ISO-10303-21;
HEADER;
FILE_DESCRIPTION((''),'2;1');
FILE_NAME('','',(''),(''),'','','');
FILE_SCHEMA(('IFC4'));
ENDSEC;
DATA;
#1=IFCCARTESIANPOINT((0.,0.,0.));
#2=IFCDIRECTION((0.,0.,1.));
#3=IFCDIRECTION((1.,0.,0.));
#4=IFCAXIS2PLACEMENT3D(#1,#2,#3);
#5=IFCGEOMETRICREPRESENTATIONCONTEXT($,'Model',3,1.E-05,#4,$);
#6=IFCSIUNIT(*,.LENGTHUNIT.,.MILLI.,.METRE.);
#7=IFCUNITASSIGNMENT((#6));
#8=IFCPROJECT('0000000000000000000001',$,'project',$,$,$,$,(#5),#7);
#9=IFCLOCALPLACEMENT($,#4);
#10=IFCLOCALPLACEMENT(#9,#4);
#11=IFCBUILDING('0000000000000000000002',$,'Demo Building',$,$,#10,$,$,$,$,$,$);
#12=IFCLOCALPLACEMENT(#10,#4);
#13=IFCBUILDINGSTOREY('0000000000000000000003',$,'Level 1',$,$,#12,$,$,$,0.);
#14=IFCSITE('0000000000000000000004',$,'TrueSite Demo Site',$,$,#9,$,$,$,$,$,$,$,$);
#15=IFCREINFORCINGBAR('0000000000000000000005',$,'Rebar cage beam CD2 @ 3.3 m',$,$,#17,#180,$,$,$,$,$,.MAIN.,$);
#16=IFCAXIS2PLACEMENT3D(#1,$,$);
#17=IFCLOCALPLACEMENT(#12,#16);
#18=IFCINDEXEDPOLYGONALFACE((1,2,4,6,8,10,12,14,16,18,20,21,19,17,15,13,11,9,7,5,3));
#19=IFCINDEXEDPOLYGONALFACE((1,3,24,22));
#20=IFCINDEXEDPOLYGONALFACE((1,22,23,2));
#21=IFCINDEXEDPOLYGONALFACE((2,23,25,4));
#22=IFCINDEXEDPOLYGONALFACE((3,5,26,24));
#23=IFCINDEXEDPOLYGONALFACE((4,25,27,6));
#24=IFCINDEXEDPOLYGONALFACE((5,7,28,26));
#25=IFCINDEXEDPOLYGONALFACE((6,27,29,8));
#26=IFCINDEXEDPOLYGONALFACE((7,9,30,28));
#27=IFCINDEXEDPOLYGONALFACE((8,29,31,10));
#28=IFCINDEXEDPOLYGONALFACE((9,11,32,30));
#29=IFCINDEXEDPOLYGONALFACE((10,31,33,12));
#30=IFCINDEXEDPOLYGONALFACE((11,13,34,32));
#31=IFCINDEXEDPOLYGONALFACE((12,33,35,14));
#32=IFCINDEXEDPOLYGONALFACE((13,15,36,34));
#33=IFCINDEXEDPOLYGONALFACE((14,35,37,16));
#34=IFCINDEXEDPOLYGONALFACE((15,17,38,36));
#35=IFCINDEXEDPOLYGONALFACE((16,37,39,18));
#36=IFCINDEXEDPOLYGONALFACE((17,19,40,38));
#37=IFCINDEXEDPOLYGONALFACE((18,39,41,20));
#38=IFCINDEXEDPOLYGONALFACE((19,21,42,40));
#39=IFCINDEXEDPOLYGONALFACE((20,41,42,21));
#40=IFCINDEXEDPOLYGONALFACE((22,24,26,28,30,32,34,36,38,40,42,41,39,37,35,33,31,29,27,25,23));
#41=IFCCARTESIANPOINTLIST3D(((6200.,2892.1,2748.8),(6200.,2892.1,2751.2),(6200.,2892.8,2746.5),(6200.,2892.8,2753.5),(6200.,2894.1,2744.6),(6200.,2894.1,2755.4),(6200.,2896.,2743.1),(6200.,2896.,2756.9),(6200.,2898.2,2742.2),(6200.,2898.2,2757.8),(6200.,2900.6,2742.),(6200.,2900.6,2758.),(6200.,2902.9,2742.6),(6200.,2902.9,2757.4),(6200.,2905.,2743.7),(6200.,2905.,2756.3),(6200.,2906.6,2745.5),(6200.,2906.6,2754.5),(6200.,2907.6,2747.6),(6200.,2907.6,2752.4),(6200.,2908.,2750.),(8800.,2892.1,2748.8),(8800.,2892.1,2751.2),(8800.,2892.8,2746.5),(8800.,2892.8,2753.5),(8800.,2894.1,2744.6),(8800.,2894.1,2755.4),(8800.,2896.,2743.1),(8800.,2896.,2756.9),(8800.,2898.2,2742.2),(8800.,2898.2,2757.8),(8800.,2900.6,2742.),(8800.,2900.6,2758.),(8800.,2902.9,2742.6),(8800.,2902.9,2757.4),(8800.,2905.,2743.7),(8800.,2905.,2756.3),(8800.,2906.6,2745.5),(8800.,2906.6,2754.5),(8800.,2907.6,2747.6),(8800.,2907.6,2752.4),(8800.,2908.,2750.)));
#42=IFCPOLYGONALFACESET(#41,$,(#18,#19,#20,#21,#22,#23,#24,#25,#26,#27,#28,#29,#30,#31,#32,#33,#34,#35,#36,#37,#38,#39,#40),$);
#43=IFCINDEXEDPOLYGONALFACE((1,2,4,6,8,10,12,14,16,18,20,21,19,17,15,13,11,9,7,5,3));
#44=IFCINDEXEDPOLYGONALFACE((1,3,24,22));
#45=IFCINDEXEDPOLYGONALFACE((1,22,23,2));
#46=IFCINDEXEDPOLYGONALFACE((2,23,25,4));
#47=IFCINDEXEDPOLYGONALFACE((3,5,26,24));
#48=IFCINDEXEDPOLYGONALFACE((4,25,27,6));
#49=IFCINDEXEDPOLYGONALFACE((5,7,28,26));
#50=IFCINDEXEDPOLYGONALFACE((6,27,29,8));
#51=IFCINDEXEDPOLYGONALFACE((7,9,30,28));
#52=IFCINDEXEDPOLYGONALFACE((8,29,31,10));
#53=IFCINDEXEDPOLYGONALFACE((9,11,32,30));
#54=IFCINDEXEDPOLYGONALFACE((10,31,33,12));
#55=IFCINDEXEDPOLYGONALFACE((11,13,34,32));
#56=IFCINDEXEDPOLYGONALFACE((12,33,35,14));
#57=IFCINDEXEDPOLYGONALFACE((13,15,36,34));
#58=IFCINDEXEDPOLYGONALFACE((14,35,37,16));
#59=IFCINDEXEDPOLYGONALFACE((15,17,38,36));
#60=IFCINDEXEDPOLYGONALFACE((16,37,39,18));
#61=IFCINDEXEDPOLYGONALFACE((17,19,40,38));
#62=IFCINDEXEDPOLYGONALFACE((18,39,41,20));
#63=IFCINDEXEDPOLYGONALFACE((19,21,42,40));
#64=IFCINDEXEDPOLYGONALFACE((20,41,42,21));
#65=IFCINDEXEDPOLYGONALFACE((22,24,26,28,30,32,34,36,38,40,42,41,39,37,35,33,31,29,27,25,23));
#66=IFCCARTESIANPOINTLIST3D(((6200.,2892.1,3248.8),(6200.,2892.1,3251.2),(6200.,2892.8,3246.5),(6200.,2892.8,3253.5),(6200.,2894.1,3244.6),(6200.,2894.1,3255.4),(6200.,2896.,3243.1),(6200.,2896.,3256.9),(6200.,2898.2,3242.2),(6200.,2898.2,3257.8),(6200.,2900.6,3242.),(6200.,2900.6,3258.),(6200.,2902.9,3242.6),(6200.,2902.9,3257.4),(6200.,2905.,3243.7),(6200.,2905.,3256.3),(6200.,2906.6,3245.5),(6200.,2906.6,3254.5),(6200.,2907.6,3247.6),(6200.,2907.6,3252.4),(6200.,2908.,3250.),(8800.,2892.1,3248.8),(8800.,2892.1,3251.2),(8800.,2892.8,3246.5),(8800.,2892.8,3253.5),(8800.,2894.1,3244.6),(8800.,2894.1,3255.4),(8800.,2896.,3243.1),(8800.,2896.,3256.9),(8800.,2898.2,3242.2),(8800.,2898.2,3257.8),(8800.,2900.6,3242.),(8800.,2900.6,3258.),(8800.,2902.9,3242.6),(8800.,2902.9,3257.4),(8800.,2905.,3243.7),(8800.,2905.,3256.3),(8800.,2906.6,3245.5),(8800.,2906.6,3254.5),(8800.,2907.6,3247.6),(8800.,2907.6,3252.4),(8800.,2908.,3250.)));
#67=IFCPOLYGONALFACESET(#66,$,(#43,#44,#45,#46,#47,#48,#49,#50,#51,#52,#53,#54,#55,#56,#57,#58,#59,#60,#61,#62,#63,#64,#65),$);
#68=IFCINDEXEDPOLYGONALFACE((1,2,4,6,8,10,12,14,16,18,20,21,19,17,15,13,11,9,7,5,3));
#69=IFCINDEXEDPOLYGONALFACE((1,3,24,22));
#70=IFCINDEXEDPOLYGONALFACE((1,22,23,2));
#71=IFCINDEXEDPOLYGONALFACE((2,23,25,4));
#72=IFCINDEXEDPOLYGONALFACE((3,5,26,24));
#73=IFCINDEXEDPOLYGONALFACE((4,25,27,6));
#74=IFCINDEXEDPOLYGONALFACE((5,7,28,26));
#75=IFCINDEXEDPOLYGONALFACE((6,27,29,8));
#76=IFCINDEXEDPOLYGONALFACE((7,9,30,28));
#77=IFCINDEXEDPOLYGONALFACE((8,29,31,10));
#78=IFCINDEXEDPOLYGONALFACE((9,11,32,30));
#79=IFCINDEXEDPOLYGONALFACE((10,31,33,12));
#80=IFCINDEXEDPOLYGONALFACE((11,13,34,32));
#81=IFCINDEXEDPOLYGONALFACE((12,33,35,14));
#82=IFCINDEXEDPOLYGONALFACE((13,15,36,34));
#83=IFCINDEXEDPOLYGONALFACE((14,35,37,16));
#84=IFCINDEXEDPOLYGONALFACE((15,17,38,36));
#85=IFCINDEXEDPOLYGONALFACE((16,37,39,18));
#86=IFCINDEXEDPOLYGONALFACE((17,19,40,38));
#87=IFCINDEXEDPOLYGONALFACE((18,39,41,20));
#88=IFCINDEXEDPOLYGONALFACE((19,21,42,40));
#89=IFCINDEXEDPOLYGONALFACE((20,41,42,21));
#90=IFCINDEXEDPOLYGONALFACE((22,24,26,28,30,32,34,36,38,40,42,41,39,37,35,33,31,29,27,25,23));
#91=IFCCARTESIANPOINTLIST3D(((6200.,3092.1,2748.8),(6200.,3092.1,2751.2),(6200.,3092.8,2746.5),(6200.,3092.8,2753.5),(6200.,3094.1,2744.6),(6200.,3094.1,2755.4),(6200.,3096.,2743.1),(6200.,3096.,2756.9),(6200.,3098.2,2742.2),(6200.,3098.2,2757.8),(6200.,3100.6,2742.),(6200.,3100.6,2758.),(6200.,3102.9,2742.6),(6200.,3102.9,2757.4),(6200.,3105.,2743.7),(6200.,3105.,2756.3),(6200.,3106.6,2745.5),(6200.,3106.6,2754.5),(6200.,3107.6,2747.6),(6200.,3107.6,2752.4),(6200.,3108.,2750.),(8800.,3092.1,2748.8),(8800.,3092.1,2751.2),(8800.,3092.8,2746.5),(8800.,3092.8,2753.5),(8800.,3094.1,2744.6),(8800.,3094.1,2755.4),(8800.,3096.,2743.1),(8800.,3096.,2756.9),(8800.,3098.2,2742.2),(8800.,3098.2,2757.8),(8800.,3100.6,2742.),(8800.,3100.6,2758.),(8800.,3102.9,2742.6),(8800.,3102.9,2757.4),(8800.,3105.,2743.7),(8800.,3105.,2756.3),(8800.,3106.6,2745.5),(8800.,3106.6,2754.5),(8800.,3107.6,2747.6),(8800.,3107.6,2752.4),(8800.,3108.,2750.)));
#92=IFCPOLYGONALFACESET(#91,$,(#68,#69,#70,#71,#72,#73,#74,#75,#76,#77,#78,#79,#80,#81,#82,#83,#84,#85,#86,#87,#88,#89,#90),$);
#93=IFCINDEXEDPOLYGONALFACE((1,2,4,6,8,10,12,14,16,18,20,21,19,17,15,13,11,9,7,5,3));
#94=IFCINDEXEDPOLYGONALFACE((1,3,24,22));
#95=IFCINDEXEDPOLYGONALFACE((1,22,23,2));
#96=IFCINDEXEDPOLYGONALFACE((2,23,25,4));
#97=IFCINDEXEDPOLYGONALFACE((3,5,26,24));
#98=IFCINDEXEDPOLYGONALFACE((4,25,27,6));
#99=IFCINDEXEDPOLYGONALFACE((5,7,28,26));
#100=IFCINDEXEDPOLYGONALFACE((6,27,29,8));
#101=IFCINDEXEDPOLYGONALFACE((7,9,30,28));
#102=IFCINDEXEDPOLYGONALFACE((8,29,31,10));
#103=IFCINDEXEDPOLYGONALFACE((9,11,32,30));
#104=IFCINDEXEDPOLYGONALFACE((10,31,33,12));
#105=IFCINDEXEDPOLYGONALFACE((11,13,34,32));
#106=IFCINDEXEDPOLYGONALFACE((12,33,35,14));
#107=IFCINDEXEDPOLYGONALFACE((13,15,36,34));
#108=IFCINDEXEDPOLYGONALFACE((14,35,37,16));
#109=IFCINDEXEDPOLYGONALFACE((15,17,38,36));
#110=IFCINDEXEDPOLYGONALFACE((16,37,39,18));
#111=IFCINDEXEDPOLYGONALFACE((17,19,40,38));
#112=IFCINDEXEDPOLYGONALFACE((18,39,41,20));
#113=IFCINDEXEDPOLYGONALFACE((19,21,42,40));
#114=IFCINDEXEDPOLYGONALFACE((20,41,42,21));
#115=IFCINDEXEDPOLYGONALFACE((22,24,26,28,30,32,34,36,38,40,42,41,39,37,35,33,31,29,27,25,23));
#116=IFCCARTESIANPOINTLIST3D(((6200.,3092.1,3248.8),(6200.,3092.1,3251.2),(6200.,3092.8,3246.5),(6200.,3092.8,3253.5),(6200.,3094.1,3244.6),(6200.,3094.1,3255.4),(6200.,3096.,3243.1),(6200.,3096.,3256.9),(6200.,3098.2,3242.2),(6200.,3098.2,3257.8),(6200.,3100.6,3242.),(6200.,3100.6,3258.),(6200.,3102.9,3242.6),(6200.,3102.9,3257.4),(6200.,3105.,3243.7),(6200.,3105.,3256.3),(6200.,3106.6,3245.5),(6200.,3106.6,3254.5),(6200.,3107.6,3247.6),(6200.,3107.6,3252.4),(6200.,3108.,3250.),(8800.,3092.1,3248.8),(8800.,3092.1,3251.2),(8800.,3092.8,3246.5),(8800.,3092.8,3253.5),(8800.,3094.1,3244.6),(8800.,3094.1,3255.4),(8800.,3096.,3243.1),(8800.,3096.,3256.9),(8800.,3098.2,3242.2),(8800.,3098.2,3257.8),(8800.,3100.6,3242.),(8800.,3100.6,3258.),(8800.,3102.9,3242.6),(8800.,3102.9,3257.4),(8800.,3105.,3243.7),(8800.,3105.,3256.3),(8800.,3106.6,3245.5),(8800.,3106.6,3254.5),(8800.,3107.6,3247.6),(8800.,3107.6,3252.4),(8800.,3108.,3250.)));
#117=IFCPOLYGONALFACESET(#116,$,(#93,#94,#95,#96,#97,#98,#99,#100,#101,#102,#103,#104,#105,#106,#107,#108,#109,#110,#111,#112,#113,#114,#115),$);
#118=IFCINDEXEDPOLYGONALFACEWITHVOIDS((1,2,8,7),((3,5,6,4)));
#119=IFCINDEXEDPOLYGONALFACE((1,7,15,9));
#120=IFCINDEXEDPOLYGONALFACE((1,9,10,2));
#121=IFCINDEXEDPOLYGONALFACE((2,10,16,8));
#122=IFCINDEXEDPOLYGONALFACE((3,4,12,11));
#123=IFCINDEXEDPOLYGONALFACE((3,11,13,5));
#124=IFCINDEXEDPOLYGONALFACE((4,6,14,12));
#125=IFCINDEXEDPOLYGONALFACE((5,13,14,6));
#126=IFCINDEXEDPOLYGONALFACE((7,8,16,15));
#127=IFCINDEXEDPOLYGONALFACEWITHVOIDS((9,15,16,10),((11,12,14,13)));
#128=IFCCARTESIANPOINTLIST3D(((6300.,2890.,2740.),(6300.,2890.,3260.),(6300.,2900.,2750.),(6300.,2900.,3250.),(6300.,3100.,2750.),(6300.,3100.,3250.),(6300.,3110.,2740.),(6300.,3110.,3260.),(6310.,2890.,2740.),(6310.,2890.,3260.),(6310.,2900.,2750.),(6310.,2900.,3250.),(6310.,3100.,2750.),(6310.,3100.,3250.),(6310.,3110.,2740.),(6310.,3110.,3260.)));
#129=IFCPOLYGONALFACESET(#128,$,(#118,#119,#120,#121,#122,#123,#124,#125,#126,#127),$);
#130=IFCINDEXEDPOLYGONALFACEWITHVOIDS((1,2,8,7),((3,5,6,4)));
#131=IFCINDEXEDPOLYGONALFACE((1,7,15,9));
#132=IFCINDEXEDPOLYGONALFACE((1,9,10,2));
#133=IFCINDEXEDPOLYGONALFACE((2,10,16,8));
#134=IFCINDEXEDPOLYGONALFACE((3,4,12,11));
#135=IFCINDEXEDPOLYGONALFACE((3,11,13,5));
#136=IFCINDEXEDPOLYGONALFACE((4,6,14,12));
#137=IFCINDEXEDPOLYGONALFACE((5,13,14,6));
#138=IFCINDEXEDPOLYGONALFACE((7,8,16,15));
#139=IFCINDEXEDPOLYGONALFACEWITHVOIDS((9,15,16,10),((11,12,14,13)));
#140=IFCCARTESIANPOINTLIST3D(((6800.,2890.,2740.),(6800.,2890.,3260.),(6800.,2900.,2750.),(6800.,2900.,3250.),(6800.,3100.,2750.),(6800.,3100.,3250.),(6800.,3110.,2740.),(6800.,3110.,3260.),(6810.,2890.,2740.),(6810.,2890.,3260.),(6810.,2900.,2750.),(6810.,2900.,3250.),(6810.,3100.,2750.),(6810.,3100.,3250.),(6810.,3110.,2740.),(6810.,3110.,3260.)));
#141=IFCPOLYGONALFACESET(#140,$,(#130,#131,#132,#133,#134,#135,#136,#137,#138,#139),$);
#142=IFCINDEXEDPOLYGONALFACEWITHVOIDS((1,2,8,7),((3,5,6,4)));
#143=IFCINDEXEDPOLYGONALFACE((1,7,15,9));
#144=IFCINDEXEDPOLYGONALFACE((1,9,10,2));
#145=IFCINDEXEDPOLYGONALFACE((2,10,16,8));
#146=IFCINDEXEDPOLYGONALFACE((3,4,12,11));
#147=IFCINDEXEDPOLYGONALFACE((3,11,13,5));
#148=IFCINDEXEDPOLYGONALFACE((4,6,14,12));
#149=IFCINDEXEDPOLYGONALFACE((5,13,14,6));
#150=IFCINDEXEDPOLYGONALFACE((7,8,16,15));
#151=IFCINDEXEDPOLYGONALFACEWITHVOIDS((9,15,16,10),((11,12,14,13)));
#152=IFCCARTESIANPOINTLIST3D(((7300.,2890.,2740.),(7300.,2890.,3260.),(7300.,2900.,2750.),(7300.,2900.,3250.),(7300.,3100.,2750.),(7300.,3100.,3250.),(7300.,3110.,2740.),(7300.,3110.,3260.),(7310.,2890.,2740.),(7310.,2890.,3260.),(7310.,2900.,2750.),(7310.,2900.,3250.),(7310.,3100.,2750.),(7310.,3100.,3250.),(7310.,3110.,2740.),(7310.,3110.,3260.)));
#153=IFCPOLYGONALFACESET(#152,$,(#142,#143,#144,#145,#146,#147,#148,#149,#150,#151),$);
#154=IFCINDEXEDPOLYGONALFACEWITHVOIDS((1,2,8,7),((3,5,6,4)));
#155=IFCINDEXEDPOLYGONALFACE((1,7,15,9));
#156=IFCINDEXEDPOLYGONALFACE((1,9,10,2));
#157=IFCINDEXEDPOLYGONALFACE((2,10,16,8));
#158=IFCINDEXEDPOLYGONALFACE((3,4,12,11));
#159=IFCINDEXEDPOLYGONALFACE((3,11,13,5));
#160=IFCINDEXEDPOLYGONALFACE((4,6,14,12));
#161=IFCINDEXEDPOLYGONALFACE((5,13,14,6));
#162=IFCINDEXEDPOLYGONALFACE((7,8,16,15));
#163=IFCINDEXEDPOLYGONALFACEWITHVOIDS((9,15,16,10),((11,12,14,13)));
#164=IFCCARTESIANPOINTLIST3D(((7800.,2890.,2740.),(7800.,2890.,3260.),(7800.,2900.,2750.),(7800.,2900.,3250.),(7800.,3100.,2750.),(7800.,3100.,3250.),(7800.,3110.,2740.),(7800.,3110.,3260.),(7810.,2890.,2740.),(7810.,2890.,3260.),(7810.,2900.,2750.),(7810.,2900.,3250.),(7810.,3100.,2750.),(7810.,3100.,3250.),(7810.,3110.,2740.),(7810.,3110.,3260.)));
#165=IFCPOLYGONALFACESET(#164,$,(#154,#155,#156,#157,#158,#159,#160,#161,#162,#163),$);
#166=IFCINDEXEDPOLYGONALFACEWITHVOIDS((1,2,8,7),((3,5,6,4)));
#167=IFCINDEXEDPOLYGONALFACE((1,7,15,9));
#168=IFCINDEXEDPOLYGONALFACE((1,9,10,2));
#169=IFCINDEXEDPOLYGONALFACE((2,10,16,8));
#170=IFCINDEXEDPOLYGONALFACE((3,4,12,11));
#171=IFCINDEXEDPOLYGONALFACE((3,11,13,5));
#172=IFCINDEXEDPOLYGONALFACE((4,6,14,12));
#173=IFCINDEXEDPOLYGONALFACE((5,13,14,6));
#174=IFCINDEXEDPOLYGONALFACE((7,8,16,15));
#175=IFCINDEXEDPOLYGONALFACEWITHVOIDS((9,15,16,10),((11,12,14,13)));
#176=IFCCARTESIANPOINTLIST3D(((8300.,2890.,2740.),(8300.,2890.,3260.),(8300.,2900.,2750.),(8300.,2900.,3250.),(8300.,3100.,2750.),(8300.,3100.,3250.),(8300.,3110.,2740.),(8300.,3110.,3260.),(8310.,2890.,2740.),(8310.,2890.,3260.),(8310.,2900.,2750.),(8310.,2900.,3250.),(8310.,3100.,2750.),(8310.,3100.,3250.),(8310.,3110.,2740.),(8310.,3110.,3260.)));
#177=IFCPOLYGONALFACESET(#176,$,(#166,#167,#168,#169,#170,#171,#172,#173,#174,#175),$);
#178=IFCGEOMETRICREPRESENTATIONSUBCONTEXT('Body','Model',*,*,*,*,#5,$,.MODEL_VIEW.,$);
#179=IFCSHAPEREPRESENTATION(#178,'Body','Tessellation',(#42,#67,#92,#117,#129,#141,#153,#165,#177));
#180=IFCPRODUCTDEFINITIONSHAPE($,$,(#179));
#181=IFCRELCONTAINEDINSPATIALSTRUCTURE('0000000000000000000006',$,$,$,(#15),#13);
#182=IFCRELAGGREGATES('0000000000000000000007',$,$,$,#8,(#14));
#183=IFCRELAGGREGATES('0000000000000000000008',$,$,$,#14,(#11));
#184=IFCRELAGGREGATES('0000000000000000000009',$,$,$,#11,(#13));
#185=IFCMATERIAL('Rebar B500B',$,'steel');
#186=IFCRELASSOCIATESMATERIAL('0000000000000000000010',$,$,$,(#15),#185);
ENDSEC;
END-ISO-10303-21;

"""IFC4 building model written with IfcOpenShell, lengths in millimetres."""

from ifc_helpers import new_model, si_unit, frame, origin_with_axes, place, context, subcontext, project, spatial, hollow_rectangle, circle, extrude, material, element, save


model = new_model("IFC4")

# Units and contexts
model_context = context("Model", 3, precision=1e-05, world=origin_with_axes())
body_context = subcontext(model_context, "Body", "Model", "MODEL_VIEW")
ifc_project = project(units=[si_unit("LENGTHUNIT", "METRE", prefix="MILLI")], contexts=[model_context])

# Site, building, storey
site_placement = place(None, origin_with_axes())
site = spatial("IfcSite", under=ifc_project, at=site_placement, Name="TrueSite Demo Site")
building_placement = place(site_placement, origin_with_axes())
building = spatial("IfcBuilding", under=site, at=building_placement, Name="Demo Building")
storey_placement = place(building_placement, origin_with_axes())
storey = spatial("IfcBuildingStorey", under=building, at=storey_placement, Name="Level 1", Elevation=0.0)

# Reinforcing bar
ifc_material_1 = material(Name="Rebar B500B", Category="steel")
for number, where, z_axis, x_axis, name in (
    (1, (6200.0, 3000.0, 3000.0), (1.0, 0.0, 0.0), (0.0, 1.0, 0.0), "Rebar cage beam CD2 @ 3.3 m"),
):
    element("IfcReinforcingBar", number, at=place(storey_placement, frame(where, z_axis=z_axis, x_axis=x_axis)), inside=storey, material=ifc_material_1, Name=name, PredefinedType="MAIN", context=body_context, shape_type="SweptSolid", body=[
        extrude(circle(Radius=8.0), frame((-100.0, -250.0, 0.0)), (0.0, 0.0, 1.0), 2600.0),
        extrude(circle(Radius=8.0), frame((-100.0, 250.0, 0.0)), (0.0, 0.0, 1.0), 2600.0),
        extrude(circle(Radius=8.0), frame((100.0, -250.0, 0.0)), (0.0, 0.0, 1.0), 2600.0),
        extrude(circle(Radius=8.0), frame((100.0, 250.0, 0.0)), (0.0, 0.0, 1.0), 2600.0),
        extrude(hollow_rectangle(XDim=220.0, YDim=520.0, WallThickness=10.0), frame((0.0, 0.0, 100.0)), (0.0, 0.0, 1.0), 10.0),
        extrude(hollow_rectangle(XDim=220.0, YDim=520.0, WallThickness=10.0), frame((0.0, 0.0, 600.0)), (0.0, 0.0, 1.0), 10.0),
        extrude(hollow_rectangle(XDim=220.0, YDim=520.0, WallThickness=10.0), frame((0.0, 0.0, 1100.0)), (0.0, 0.0, 1.0), 10.0),
        extrude(hollow_rectangle(XDim=220.0, YDim=520.0, WallThickness=10.0), frame((0.0, 0.0, 1600.0)), (0.0, 0.0, 1.0), 10.0),
        extrude(hollow_rectangle(XDim=220.0, YDim=520.0, WallThickness=10.0), frame((0.0, 0.0, 2100.0)), (0.0, 0.0, 1.0), 10.0),
    ])

save(model, "model.ifc")
